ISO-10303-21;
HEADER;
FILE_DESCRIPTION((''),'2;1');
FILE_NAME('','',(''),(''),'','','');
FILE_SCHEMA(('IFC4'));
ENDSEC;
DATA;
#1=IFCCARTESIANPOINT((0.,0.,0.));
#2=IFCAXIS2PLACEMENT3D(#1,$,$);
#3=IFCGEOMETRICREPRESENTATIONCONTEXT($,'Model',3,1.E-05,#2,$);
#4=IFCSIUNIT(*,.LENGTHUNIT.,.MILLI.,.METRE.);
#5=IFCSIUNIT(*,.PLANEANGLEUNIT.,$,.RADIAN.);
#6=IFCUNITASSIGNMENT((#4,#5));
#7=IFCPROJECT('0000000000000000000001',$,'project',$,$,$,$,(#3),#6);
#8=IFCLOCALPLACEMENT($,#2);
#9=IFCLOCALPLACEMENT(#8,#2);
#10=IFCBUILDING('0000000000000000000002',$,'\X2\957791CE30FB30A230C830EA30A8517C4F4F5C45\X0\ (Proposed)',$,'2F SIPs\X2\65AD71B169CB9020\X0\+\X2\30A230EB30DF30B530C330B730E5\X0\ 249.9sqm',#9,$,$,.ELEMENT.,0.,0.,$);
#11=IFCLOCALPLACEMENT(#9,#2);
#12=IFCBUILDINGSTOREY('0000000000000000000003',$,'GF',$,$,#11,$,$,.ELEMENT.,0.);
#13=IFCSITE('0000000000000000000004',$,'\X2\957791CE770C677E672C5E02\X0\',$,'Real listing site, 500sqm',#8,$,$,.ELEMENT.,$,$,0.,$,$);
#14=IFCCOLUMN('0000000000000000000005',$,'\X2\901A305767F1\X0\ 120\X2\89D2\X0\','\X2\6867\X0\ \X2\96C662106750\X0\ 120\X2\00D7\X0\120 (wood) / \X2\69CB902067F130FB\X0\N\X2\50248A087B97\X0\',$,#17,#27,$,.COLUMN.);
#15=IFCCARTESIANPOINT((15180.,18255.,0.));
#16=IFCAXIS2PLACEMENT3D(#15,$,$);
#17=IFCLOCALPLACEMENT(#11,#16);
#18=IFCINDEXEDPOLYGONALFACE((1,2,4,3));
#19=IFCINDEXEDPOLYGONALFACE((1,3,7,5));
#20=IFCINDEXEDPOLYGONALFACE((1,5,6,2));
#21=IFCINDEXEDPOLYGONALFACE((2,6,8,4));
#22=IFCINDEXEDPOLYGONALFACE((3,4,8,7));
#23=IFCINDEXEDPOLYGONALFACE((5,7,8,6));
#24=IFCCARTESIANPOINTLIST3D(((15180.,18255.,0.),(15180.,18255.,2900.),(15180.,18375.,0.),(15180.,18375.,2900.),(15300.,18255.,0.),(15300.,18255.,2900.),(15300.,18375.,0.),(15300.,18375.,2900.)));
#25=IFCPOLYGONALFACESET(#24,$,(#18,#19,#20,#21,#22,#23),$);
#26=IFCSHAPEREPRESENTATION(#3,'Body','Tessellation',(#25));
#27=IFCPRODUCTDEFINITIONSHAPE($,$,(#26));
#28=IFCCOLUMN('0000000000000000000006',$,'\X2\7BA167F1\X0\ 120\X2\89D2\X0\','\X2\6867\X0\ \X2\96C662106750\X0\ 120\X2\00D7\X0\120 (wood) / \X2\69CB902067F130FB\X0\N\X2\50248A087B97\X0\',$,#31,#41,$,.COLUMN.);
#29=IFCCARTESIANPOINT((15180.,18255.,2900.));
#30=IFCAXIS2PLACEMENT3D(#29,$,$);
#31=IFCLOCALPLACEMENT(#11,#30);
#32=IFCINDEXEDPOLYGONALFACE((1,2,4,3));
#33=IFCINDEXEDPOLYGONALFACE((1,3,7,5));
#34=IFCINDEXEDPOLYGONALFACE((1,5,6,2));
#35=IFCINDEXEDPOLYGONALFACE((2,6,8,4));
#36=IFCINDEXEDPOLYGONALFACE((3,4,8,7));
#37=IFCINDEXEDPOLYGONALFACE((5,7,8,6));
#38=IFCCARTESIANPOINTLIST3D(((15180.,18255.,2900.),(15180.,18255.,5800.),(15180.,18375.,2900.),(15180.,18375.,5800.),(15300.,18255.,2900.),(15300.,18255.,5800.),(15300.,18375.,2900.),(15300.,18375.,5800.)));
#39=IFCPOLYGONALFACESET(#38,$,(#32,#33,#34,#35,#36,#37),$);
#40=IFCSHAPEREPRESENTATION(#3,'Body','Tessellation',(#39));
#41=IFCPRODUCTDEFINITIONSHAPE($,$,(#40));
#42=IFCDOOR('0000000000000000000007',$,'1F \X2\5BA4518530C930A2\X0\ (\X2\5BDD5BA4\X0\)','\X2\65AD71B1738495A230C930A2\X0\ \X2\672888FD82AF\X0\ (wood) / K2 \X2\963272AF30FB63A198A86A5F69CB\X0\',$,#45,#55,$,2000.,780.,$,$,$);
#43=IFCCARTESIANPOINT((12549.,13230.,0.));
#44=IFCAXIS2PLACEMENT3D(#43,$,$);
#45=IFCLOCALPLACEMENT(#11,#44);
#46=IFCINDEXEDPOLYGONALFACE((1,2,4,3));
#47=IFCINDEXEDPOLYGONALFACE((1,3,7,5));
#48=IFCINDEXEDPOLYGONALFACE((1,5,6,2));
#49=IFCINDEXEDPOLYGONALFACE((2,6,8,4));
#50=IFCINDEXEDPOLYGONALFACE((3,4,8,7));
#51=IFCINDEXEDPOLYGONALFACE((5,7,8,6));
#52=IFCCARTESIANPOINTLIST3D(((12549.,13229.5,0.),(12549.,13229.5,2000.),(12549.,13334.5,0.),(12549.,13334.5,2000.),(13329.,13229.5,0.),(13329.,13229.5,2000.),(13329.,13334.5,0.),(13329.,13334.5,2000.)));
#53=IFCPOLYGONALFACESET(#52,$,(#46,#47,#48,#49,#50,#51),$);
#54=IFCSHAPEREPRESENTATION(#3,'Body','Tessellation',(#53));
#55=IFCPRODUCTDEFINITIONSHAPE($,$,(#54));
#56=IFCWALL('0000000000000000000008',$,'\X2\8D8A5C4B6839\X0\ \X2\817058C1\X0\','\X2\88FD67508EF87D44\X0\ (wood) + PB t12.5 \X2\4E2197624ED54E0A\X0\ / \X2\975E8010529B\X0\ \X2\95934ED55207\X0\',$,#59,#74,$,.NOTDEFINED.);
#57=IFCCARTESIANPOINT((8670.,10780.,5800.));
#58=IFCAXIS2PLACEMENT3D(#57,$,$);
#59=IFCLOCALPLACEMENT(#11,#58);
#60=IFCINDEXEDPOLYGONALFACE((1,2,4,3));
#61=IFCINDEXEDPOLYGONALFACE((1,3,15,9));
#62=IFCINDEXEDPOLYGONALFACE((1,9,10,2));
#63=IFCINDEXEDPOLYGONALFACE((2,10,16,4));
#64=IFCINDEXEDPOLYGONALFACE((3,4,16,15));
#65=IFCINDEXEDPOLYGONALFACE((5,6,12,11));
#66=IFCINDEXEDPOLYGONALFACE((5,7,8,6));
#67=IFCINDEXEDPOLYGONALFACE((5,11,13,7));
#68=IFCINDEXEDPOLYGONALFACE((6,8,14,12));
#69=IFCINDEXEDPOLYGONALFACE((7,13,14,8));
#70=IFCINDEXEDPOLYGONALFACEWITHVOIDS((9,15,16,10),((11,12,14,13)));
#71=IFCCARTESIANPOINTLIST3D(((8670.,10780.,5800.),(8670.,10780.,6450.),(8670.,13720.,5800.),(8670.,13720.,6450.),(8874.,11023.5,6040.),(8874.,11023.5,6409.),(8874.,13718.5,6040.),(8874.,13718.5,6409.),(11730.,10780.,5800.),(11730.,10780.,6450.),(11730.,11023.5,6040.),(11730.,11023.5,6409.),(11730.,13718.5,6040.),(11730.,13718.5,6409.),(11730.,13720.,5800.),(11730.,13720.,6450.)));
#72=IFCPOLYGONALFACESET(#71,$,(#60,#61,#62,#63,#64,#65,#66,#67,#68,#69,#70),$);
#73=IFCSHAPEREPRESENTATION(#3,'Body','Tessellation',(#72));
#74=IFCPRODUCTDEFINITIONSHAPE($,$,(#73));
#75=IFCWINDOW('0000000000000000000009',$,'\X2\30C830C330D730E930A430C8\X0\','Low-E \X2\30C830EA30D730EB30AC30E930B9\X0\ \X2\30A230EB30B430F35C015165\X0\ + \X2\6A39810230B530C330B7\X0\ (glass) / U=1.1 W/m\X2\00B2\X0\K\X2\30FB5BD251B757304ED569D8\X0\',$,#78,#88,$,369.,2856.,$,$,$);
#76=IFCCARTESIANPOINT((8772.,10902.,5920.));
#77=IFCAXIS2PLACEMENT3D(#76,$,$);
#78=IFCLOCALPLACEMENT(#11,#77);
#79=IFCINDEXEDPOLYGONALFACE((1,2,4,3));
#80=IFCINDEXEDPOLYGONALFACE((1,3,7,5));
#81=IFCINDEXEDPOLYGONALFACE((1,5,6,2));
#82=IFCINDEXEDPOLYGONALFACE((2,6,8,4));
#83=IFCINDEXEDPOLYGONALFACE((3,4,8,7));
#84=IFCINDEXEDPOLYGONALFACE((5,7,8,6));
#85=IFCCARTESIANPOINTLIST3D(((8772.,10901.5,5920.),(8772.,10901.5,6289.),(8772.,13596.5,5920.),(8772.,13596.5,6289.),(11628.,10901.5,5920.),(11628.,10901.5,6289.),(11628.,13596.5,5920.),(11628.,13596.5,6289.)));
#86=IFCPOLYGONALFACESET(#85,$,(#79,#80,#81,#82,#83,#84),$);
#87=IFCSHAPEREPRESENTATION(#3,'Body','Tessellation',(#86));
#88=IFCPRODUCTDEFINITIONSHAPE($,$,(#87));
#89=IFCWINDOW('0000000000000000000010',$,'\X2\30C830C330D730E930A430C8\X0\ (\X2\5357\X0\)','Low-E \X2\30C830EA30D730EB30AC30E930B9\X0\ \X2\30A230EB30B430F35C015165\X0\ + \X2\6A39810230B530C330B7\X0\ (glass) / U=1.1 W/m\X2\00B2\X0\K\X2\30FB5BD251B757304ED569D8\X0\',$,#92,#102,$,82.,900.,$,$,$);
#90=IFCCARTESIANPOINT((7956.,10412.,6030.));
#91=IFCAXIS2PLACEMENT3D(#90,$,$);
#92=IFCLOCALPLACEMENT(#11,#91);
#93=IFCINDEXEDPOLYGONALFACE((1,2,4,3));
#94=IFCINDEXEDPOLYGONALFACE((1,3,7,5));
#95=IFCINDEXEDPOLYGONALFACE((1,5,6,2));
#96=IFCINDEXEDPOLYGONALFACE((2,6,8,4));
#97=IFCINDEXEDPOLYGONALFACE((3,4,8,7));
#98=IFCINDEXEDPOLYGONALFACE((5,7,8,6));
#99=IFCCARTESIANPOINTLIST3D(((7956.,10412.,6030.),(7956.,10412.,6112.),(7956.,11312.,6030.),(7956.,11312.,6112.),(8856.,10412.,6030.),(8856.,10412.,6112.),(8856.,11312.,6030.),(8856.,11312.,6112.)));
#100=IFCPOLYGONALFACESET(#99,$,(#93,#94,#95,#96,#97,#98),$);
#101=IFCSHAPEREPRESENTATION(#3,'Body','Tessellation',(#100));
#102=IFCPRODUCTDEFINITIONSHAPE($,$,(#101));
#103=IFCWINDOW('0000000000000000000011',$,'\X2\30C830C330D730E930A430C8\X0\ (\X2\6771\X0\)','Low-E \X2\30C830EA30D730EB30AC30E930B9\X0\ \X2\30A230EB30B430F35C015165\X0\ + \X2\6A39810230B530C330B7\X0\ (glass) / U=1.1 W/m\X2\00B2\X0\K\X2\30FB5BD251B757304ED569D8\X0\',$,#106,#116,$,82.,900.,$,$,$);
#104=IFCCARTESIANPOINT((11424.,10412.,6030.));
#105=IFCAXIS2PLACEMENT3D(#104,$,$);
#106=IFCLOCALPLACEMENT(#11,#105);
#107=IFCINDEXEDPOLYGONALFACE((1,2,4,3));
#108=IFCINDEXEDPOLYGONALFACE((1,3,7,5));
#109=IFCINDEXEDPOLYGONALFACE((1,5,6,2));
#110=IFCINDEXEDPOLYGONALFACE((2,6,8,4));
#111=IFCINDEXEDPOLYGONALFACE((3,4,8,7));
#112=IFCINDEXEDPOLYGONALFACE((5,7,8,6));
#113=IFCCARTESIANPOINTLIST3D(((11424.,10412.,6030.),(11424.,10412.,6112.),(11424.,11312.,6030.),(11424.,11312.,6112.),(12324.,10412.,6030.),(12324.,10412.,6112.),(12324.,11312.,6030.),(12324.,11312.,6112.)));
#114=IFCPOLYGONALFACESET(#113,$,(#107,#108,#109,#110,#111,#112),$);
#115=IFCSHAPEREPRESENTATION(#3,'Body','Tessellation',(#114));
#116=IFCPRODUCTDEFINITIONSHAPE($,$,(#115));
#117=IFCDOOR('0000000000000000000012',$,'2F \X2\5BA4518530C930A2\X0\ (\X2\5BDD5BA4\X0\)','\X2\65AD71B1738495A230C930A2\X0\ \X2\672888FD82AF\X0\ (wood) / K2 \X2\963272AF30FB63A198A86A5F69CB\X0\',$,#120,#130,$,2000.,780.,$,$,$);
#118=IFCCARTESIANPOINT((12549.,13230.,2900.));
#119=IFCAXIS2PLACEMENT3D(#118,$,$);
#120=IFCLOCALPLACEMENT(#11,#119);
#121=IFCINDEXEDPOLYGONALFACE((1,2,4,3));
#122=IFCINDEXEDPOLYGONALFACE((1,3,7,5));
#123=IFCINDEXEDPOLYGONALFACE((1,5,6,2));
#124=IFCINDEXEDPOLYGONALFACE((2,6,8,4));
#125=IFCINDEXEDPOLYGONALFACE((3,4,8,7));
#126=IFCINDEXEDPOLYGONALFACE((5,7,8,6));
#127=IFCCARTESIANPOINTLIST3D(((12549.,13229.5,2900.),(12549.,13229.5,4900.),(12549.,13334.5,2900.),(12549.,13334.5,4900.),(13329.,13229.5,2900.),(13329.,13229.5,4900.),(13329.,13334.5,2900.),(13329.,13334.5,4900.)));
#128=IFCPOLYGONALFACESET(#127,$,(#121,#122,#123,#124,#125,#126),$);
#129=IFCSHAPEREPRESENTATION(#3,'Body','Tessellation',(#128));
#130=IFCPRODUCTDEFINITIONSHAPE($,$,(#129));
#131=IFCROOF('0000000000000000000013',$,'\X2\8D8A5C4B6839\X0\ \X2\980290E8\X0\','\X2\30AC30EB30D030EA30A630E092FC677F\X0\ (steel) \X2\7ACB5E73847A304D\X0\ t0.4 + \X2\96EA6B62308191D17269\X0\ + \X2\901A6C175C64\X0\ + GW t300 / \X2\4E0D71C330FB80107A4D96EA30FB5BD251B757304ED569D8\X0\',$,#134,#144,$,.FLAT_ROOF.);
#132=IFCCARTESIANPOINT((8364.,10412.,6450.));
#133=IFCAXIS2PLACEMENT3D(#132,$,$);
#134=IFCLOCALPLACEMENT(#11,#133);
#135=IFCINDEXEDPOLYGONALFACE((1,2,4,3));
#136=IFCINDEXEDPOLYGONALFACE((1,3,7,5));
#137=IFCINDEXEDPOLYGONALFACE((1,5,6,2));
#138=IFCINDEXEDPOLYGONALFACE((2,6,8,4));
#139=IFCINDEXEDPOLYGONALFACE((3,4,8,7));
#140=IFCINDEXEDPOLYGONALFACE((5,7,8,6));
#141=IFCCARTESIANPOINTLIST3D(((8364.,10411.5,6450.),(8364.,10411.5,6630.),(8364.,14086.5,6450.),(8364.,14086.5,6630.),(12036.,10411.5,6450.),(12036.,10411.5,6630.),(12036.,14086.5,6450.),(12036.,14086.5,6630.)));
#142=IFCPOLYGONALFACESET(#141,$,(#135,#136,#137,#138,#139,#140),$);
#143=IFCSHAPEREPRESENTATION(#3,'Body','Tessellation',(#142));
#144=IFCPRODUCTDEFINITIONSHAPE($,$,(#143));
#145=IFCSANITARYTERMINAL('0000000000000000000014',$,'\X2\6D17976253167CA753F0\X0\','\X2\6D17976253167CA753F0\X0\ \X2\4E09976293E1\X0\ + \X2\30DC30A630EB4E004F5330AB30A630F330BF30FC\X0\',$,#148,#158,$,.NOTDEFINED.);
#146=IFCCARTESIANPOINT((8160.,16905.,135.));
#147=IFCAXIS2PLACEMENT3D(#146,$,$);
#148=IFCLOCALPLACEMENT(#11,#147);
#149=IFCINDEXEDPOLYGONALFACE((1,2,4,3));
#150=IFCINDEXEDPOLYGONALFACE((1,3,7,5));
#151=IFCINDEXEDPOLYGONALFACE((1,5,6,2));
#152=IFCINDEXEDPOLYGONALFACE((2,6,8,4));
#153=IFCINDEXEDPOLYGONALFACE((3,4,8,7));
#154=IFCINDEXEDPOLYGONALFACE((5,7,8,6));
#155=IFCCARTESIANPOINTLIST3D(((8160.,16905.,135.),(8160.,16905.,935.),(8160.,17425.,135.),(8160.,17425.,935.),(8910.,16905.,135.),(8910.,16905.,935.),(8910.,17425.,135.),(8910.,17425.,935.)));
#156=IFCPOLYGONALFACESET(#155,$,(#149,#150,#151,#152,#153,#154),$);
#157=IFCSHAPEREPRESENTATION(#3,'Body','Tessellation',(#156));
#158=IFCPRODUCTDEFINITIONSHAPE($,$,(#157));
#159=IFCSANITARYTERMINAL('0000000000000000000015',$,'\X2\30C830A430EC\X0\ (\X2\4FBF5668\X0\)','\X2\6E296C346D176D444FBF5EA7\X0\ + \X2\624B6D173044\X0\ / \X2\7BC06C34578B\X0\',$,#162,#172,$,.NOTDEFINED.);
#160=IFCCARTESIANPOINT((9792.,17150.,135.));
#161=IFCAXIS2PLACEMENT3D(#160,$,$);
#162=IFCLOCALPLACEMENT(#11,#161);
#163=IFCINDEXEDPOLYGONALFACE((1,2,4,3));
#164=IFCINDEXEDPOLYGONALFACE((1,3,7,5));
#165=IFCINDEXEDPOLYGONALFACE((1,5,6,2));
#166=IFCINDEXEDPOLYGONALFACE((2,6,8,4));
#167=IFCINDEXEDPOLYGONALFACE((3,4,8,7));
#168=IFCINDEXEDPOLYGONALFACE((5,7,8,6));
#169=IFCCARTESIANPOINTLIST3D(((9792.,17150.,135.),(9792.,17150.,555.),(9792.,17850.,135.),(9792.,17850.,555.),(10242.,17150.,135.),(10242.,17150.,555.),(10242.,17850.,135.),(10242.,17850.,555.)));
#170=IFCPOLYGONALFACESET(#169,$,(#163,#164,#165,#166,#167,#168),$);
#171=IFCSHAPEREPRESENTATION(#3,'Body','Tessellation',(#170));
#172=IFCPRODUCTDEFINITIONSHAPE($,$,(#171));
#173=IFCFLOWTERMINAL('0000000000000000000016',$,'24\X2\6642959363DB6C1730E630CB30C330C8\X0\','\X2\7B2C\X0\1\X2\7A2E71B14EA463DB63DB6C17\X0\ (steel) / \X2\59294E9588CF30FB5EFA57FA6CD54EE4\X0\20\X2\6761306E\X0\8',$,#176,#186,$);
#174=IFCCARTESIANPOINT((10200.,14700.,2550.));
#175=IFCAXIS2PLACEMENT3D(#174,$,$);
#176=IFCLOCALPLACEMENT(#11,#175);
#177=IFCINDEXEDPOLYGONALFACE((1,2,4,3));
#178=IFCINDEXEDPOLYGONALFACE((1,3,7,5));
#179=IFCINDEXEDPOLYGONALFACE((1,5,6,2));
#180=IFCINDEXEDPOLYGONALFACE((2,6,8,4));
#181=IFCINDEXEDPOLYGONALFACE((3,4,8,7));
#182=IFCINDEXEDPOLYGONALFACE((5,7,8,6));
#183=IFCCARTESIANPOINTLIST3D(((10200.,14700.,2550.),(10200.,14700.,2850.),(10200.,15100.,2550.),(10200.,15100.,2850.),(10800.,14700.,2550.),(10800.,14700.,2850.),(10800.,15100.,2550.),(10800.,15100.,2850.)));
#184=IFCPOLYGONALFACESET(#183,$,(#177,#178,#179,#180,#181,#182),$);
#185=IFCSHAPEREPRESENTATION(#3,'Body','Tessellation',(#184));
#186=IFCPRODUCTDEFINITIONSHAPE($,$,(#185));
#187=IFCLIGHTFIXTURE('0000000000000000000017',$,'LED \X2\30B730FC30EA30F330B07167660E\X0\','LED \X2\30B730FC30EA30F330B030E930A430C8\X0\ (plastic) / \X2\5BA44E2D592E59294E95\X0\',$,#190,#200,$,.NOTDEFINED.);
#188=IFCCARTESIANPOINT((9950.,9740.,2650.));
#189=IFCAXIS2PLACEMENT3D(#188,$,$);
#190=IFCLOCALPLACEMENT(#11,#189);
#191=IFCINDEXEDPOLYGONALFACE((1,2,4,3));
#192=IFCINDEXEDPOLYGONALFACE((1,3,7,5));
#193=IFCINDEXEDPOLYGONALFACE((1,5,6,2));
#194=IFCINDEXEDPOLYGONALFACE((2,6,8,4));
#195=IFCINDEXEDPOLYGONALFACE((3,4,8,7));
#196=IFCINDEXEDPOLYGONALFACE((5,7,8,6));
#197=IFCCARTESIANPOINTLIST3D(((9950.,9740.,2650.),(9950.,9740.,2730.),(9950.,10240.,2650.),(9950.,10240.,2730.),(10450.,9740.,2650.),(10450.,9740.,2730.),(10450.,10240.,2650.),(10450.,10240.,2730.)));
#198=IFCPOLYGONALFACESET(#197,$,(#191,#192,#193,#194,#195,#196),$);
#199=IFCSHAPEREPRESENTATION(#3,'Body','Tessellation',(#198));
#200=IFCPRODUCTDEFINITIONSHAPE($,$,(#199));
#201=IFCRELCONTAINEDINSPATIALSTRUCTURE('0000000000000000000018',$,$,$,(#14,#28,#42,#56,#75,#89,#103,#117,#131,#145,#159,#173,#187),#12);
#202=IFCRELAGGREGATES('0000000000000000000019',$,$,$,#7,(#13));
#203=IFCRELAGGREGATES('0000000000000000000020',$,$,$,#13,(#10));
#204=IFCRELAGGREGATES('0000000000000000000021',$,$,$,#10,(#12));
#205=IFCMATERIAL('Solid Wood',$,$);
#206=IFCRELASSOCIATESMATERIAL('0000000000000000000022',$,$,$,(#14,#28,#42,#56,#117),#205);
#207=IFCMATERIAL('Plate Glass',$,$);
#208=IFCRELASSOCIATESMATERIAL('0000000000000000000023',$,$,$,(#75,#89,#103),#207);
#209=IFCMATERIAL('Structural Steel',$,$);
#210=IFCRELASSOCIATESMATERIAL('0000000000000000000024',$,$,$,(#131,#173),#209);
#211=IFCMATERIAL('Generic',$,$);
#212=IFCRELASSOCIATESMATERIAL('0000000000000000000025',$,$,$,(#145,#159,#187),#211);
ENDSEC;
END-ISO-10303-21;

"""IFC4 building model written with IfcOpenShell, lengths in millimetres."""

from ifc_helpers import new_model, si_unit, frame, frame_2d, origin, place, context, project, spatial, rectangle, extrude, material, element, fill, save


model = new_model("IFC4")

# Units and contexts
model_context = context("Model", 3, precision=1e-05, world=origin())
ifc_project = project(units=[si_unit("LENGTHUNIT", "METRE", prefix="MILLI"), si_unit("PLANEANGLEUNIT", "RADIAN")], contexts=[model_context])

# Site, building, storey
site_placement = place(None, origin())
site = spatial("IfcSite", under=ifc_project, at=site_placement, Name="長野県松本市", ObjectType="Real listing site, 500sqm", CompositionType="ELEMENT", RefElevation=0.0)
building_placement = place(site_placement, origin())
building = spatial("IfcBuilding", under=site, at=building_placement, Name="長野・アトリエ兼住居 (Proposed)", ObjectType="2F SIPs断熱構造+アルミサッシュ 249.9sqm", CompositionType="ELEMENT", ElevationOfRefHeight=0.0, ElevationOfTerrain=0.0)
storey_placement = place(building_placement, origin())
storey = spatial("IfcBuildingStorey", under=building, at=storey_placement, Name="GF", CompositionType="ELEMENT", Elevation=0.0)

# Columns
ifc_material_1 = material(Name="Solid Wood")
column_1_placement = place(storey_placement, frame((15180.0, 18255.0, 0.0)))
element("IfcColumn", 1, at=column_1_placement, inside=storey, material=ifc_material_1, Name="通し柱 120角", Description="桧 集成材 120×120 (wood) / 構造柱・N値計算", PredefinedType="COLUMN", context=model_context, shape_type="SweptSolid", body=[
    extrude(rectangle(XDim=120.0, YDim=120.0, at=frame_2d((60.0, 60.0))), frame((15180.0, 18255.0, 0.0)), (0.0, 0.0, 1.0), 2900.0),
])
column_2_placement = place(storey_placement, frame((15180.0, 18255.0, 2900.0)))
element("IfcColumn", 2, at=column_2_placement, inside=storey, material=ifc_material_1, Name="管柱 120角", Description="桧 集成材 120×120 (wood) / 構造柱・N値計算", PredefinedType="COLUMN", context=model_context, shape_type="SweptSolid", body=[
    extrude(rectangle(XDim=120.0, YDim=120.0, at=frame_2d((60.0, 60.0))), frame((15180.0, 18255.0, 2900.0)), (0.0, 0.0, 1.0), 2900.0),
])

# Door
door_1_placement = place(storey_placement, frame((12549.0, 13230.0, 0.0)))
element("IfcDoor", 3, at=door_1_placement, inside=storey, material=ifc_material_1, Name="1F 室内ドア (寝室)", Description="断熱玄関ドア 木製芯 (wood) / K2 防犯・採風機構", OverallHeight=2000.0, OverallWidth=780.0, context=model_context, shape_type="SweptSolid", body=[
    extrude(rectangle(XDim=780.0, YDim=105.0, at=frame_2d((390.0, 52.0))), frame((12549.0, 13230.0, 0.0)), (0.0, 0.0, 1.0), 2000.0),
])

# Wall, openings, windows
wall_1_placement = place(storey_placement, frame((8670.0, 10780.0, 5800.0)))
wall_1 = element("IfcWall", 4, at=wall_1_placement, inside=storey, material=ifc_material_1, Name="越屋根 腰壁", Description="製材軸組 (wood) + PB t12.5 両面仕上 / 非耐力 間仕切", PredefinedType="NOTDEFINED", context=model_context, shape_type="SweptSolid", body=[
    extrude(rectangle(XDim=3060.0, YDim=2940.0, at=frame_2d((1530.0, 1470.0))), frame((8670.0, 10780.0, 5800.0)), (0.0, 0.0, 1.0), 650.0),
])
opening_1_placement = place(storey_placement, frame((8772.0, 10902.0, 5920.0)))
opening_1 = element("IfcOpeningElement", 5, at=opening_1_placement, cuts=wall_1, PredefinedType="NOTDEFINED", context=model_context, shape_type="SweptSolid", body=[
    extrude(rectangle(XDim=2856.0, YDim=2695.0, at=frame_2d((1428.0, 1347.0))), frame((8772.0, 10902.0, 5920.0)), (0.0, 0.0, 1.0), 369.0),
])
opening_2_placement = place(storey_placement, frame((7956.0, 10412.0, 6030.0)))
opening_2 = element("IfcOpeningElement", 6, at=opening_2_placement, cuts=wall_1, PredefinedType="NOTDEFINED", context=model_context, shape_type="SweptSolid", body=[
    extrude(rectangle(XDim=900.0, YDim=900.0, at=frame_2d((450.0, 450.0))), frame((7956.0, 10412.0, 6030.0)), (0.0, 0.0, 1.0), 82.0),
])
opening_3_placement = place(storey_placement, frame((11424.0, 10412.0, 6030.0)))
opening_3 = element("IfcOpeningElement", 7, at=opening_3_placement, cuts=wall_1, PredefinedType="NOTDEFINED", context=model_context, shape_type="SweptSolid", body=[
    extrude(rectangle(XDim=900.0, YDim=900.0, at=frame_2d((450.0, 450.0))), frame((11424.0, 10412.0, 6030.0)), (0.0, 0.0, 1.0), 82.0),
])
ifc_material_2 = material(Name="Plate Glass")
window_1_placement = place(storey_placement, frame((8772.0, 10902.0, 5920.0)))
window_1 = element("IfcWindow", 8, at=window_1_placement, inside=storey, material=ifc_material_2, Name="トップライト", Description="Low-E トリプルガラス アルゴン封入 + 樹脂サッシ (glass) / U=1.1 W/m²K・寒冷地仕様", OverallHeight=369.0, OverallWidth=2856.0, context=model_context, shape_type="SweptSolid", body=[
    extrude(rectangle(XDim=2856.0, YDim=2695.0, at=frame_2d((1428.0, 1347.0))), frame((8772.0, 10902.0, 5920.0)), (0.0, 0.0, 1.0), 369.0),
])
fill(opening_1, window_1)
window_2_placement = place(storey_placement, frame((7956.0, 10412.0, 6030.0)))
window_2 = element("IfcWindow", 9, at=window_2_placement, inside=storey, material=ifc_material_2, Name="トップライト (南)", Description="Low-E トリプルガラス アルゴン封入 + 樹脂サッシ (glass) / U=1.1 W/m²K・寒冷地仕様", OverallHeight=82.0, OverallWidth=900.0, context=model_context, shape_type="SweptSolid", body=[
    extrude(rectangle(XDim=900.0, YDim=900.0, at=frame_2d((450.0, 450.0))), frame((7956.0, 10412.0, 6030.0)), (0.0, 0.0, 1.0), 82.0),
])
fill(opening_2, window_2)
window_3_placement = place(storey_placement, frame((11424.0, 10412.0, 6030.0)))
window_3 = element("IfcWindow", 10, at=window_3_placement, inside=storey, material=ifc_material_2, Name="トップライト (東)", Description="Low-E トリプルガラス アルゴン封入 + 樹脂サッシ (glass) / U=1.1 W/m²K・寒冷地仕様", OverallHeight=82.0, OverallWidth=900.0, context=model_context, shape_type="SweptSolid", body=[
    extrude(rectangle(XDim=900.0, YDim=900.0, at=frame_2d((450.0, 450.0))), frame((11424.0, 10412.0, 6030.0)), (0.0, 0.0, 1.0), 82.0),
])
fill(opening_3, window_3)

# Door
door_2_placement = place(storey_placement, frame((12549.0, 13230.0, 2900.0)))
element("IfcDoor", 11, at=door_2_placement, inside=storey, material=ifc_material_1, Name="2F 室内ドア (寝室)", Description="断熱玄関ドア 木製芯 (wood) / K2 防犯・採風機構", OverallHeight=2000.0, OverallWidth=780.0, context=model_context, shape_type="SweptSolid", body=[
    extrude(rectangle(XDim=780.0, YDim=105.0, at=frame_2d((390.0, 52.0))), frame((12549.0, 13230.0, 2900.0)), (0.0, 0.0, 1.0), 2000.0),
])

# Roof
ifc_material_3 = material(Name="Structural Steel")
roof_placement = place(storey_placement, frame((8364.0, 10412.0, 6450.0)))
element("IfcRoof", 12, at=roof_placement, inside=storey, material=ifc_material_3, Name="越屋根 頂部", Description="ガルバリウム鋼板 (steel) 立平葺き t0.4 + 雪止め金物 + 通気層 + GW t300 / 不燃・耐積雪・寒冷地仕様", PredefinedType="FLAT_ROOF", context=model_context, shape_type="SweptSolid", body=[
    extrude(rectangle(XDim=3672.0, YDim=3675.0, at=frame_2d((1836.0, 1837.0))), frame((8364.0, 10412.0, 6450.0)), (0.0, 0.0, 1.0), 180.0),
])

# Sanitary terminals
ifc_material_4 = material(Name="Generic")
sanitary_terminal_1_placement = place(storey_placement, frame((8160.0, 16905.0, 135.0)))
element("IfcSanitaryTerminal", 13, at=sanitary_terminal_1_placement, inside=storey, material=ifc_material_4, Name="洗面化粧台", Description="洗面化粧台 三面鏡 + ボウル一体カウンター", PredefinedType="NOTDEFINED", context=model_context, shape_type="SweptSolid", body=[
    extrude(rectangle(XDim=750.0, YDim=520.0, at=frame_2d((375.0, 260.0))), frame((8160.0, 16905.0, 135.0)), (0.0, 0.0, 1.0), 800.0),
])
sanitary_terminal_2_placement = place(storey_placement, frame((9792.0, 17150.0, 135.0)))
element("IfcSanitaryTerminal", 14, at=sanitary_terminal_2_placement, inside=storey, material=ifc_material_4, Name="トイレ (便器)", Description="温水洗浄便座 + 手洗い / 節水型", PredefinedType="NOTDEFINED", context=model_context, shape_type="SweptSolid", body=[
    extrude(rectangle(XDim=450.0, YDim=700.0, at=frame_2d((225.0, 350.0))), frame((9792.0, 17150.0, 135.0)), (0.0, 0.0, 1.0), 420.0),
])

# Flow terminal
flow_terminal_placement = place(storey_placement, frame((10200.0, 14700.0, 2550.0)))
element("IfcFlowTerminal", 15, at=flow_terminal_placement, inside=storey, material=ifc_material_3, Name="24時間換気ユニット", Description="第1種熱交換換気 (steel) / 天井裏・建基法令20条の8", context=model_context, shape_type="SweptSolid", body=[
    extrude(rectangle(XDim=600.0, YDim=400.0, at=frame_2d((300.0, 200.0))), frame((10200.0, 14700.0, 2550.0)), (0.0, 0.0, 1.0), 300.0),
])

# Light fixture
light_fixture_1_placement = place(storey_placement, frame((9950.0, 9740.0, 2650.0)))
element("IfcLightFixture", 16, at=light_fixture_1_placement, inside=storey, material=ifc_material_4, Name="LED シーリング照明", Description="LED シーリングライト (plastic) / 室中央天井", PredefinedType="NOTDEFINED", context=model_context, shape_type="SweptSolid", body=[
    extrude(rectangle(XDim=500.0, YDim=500.0, at=frame_2d((250.0, 250.0))), frame((9950.0, 9740.0, 2650.0)), (0.0, 0.0, 1.0), 80.0),
])

save(model, "model.ifc")
